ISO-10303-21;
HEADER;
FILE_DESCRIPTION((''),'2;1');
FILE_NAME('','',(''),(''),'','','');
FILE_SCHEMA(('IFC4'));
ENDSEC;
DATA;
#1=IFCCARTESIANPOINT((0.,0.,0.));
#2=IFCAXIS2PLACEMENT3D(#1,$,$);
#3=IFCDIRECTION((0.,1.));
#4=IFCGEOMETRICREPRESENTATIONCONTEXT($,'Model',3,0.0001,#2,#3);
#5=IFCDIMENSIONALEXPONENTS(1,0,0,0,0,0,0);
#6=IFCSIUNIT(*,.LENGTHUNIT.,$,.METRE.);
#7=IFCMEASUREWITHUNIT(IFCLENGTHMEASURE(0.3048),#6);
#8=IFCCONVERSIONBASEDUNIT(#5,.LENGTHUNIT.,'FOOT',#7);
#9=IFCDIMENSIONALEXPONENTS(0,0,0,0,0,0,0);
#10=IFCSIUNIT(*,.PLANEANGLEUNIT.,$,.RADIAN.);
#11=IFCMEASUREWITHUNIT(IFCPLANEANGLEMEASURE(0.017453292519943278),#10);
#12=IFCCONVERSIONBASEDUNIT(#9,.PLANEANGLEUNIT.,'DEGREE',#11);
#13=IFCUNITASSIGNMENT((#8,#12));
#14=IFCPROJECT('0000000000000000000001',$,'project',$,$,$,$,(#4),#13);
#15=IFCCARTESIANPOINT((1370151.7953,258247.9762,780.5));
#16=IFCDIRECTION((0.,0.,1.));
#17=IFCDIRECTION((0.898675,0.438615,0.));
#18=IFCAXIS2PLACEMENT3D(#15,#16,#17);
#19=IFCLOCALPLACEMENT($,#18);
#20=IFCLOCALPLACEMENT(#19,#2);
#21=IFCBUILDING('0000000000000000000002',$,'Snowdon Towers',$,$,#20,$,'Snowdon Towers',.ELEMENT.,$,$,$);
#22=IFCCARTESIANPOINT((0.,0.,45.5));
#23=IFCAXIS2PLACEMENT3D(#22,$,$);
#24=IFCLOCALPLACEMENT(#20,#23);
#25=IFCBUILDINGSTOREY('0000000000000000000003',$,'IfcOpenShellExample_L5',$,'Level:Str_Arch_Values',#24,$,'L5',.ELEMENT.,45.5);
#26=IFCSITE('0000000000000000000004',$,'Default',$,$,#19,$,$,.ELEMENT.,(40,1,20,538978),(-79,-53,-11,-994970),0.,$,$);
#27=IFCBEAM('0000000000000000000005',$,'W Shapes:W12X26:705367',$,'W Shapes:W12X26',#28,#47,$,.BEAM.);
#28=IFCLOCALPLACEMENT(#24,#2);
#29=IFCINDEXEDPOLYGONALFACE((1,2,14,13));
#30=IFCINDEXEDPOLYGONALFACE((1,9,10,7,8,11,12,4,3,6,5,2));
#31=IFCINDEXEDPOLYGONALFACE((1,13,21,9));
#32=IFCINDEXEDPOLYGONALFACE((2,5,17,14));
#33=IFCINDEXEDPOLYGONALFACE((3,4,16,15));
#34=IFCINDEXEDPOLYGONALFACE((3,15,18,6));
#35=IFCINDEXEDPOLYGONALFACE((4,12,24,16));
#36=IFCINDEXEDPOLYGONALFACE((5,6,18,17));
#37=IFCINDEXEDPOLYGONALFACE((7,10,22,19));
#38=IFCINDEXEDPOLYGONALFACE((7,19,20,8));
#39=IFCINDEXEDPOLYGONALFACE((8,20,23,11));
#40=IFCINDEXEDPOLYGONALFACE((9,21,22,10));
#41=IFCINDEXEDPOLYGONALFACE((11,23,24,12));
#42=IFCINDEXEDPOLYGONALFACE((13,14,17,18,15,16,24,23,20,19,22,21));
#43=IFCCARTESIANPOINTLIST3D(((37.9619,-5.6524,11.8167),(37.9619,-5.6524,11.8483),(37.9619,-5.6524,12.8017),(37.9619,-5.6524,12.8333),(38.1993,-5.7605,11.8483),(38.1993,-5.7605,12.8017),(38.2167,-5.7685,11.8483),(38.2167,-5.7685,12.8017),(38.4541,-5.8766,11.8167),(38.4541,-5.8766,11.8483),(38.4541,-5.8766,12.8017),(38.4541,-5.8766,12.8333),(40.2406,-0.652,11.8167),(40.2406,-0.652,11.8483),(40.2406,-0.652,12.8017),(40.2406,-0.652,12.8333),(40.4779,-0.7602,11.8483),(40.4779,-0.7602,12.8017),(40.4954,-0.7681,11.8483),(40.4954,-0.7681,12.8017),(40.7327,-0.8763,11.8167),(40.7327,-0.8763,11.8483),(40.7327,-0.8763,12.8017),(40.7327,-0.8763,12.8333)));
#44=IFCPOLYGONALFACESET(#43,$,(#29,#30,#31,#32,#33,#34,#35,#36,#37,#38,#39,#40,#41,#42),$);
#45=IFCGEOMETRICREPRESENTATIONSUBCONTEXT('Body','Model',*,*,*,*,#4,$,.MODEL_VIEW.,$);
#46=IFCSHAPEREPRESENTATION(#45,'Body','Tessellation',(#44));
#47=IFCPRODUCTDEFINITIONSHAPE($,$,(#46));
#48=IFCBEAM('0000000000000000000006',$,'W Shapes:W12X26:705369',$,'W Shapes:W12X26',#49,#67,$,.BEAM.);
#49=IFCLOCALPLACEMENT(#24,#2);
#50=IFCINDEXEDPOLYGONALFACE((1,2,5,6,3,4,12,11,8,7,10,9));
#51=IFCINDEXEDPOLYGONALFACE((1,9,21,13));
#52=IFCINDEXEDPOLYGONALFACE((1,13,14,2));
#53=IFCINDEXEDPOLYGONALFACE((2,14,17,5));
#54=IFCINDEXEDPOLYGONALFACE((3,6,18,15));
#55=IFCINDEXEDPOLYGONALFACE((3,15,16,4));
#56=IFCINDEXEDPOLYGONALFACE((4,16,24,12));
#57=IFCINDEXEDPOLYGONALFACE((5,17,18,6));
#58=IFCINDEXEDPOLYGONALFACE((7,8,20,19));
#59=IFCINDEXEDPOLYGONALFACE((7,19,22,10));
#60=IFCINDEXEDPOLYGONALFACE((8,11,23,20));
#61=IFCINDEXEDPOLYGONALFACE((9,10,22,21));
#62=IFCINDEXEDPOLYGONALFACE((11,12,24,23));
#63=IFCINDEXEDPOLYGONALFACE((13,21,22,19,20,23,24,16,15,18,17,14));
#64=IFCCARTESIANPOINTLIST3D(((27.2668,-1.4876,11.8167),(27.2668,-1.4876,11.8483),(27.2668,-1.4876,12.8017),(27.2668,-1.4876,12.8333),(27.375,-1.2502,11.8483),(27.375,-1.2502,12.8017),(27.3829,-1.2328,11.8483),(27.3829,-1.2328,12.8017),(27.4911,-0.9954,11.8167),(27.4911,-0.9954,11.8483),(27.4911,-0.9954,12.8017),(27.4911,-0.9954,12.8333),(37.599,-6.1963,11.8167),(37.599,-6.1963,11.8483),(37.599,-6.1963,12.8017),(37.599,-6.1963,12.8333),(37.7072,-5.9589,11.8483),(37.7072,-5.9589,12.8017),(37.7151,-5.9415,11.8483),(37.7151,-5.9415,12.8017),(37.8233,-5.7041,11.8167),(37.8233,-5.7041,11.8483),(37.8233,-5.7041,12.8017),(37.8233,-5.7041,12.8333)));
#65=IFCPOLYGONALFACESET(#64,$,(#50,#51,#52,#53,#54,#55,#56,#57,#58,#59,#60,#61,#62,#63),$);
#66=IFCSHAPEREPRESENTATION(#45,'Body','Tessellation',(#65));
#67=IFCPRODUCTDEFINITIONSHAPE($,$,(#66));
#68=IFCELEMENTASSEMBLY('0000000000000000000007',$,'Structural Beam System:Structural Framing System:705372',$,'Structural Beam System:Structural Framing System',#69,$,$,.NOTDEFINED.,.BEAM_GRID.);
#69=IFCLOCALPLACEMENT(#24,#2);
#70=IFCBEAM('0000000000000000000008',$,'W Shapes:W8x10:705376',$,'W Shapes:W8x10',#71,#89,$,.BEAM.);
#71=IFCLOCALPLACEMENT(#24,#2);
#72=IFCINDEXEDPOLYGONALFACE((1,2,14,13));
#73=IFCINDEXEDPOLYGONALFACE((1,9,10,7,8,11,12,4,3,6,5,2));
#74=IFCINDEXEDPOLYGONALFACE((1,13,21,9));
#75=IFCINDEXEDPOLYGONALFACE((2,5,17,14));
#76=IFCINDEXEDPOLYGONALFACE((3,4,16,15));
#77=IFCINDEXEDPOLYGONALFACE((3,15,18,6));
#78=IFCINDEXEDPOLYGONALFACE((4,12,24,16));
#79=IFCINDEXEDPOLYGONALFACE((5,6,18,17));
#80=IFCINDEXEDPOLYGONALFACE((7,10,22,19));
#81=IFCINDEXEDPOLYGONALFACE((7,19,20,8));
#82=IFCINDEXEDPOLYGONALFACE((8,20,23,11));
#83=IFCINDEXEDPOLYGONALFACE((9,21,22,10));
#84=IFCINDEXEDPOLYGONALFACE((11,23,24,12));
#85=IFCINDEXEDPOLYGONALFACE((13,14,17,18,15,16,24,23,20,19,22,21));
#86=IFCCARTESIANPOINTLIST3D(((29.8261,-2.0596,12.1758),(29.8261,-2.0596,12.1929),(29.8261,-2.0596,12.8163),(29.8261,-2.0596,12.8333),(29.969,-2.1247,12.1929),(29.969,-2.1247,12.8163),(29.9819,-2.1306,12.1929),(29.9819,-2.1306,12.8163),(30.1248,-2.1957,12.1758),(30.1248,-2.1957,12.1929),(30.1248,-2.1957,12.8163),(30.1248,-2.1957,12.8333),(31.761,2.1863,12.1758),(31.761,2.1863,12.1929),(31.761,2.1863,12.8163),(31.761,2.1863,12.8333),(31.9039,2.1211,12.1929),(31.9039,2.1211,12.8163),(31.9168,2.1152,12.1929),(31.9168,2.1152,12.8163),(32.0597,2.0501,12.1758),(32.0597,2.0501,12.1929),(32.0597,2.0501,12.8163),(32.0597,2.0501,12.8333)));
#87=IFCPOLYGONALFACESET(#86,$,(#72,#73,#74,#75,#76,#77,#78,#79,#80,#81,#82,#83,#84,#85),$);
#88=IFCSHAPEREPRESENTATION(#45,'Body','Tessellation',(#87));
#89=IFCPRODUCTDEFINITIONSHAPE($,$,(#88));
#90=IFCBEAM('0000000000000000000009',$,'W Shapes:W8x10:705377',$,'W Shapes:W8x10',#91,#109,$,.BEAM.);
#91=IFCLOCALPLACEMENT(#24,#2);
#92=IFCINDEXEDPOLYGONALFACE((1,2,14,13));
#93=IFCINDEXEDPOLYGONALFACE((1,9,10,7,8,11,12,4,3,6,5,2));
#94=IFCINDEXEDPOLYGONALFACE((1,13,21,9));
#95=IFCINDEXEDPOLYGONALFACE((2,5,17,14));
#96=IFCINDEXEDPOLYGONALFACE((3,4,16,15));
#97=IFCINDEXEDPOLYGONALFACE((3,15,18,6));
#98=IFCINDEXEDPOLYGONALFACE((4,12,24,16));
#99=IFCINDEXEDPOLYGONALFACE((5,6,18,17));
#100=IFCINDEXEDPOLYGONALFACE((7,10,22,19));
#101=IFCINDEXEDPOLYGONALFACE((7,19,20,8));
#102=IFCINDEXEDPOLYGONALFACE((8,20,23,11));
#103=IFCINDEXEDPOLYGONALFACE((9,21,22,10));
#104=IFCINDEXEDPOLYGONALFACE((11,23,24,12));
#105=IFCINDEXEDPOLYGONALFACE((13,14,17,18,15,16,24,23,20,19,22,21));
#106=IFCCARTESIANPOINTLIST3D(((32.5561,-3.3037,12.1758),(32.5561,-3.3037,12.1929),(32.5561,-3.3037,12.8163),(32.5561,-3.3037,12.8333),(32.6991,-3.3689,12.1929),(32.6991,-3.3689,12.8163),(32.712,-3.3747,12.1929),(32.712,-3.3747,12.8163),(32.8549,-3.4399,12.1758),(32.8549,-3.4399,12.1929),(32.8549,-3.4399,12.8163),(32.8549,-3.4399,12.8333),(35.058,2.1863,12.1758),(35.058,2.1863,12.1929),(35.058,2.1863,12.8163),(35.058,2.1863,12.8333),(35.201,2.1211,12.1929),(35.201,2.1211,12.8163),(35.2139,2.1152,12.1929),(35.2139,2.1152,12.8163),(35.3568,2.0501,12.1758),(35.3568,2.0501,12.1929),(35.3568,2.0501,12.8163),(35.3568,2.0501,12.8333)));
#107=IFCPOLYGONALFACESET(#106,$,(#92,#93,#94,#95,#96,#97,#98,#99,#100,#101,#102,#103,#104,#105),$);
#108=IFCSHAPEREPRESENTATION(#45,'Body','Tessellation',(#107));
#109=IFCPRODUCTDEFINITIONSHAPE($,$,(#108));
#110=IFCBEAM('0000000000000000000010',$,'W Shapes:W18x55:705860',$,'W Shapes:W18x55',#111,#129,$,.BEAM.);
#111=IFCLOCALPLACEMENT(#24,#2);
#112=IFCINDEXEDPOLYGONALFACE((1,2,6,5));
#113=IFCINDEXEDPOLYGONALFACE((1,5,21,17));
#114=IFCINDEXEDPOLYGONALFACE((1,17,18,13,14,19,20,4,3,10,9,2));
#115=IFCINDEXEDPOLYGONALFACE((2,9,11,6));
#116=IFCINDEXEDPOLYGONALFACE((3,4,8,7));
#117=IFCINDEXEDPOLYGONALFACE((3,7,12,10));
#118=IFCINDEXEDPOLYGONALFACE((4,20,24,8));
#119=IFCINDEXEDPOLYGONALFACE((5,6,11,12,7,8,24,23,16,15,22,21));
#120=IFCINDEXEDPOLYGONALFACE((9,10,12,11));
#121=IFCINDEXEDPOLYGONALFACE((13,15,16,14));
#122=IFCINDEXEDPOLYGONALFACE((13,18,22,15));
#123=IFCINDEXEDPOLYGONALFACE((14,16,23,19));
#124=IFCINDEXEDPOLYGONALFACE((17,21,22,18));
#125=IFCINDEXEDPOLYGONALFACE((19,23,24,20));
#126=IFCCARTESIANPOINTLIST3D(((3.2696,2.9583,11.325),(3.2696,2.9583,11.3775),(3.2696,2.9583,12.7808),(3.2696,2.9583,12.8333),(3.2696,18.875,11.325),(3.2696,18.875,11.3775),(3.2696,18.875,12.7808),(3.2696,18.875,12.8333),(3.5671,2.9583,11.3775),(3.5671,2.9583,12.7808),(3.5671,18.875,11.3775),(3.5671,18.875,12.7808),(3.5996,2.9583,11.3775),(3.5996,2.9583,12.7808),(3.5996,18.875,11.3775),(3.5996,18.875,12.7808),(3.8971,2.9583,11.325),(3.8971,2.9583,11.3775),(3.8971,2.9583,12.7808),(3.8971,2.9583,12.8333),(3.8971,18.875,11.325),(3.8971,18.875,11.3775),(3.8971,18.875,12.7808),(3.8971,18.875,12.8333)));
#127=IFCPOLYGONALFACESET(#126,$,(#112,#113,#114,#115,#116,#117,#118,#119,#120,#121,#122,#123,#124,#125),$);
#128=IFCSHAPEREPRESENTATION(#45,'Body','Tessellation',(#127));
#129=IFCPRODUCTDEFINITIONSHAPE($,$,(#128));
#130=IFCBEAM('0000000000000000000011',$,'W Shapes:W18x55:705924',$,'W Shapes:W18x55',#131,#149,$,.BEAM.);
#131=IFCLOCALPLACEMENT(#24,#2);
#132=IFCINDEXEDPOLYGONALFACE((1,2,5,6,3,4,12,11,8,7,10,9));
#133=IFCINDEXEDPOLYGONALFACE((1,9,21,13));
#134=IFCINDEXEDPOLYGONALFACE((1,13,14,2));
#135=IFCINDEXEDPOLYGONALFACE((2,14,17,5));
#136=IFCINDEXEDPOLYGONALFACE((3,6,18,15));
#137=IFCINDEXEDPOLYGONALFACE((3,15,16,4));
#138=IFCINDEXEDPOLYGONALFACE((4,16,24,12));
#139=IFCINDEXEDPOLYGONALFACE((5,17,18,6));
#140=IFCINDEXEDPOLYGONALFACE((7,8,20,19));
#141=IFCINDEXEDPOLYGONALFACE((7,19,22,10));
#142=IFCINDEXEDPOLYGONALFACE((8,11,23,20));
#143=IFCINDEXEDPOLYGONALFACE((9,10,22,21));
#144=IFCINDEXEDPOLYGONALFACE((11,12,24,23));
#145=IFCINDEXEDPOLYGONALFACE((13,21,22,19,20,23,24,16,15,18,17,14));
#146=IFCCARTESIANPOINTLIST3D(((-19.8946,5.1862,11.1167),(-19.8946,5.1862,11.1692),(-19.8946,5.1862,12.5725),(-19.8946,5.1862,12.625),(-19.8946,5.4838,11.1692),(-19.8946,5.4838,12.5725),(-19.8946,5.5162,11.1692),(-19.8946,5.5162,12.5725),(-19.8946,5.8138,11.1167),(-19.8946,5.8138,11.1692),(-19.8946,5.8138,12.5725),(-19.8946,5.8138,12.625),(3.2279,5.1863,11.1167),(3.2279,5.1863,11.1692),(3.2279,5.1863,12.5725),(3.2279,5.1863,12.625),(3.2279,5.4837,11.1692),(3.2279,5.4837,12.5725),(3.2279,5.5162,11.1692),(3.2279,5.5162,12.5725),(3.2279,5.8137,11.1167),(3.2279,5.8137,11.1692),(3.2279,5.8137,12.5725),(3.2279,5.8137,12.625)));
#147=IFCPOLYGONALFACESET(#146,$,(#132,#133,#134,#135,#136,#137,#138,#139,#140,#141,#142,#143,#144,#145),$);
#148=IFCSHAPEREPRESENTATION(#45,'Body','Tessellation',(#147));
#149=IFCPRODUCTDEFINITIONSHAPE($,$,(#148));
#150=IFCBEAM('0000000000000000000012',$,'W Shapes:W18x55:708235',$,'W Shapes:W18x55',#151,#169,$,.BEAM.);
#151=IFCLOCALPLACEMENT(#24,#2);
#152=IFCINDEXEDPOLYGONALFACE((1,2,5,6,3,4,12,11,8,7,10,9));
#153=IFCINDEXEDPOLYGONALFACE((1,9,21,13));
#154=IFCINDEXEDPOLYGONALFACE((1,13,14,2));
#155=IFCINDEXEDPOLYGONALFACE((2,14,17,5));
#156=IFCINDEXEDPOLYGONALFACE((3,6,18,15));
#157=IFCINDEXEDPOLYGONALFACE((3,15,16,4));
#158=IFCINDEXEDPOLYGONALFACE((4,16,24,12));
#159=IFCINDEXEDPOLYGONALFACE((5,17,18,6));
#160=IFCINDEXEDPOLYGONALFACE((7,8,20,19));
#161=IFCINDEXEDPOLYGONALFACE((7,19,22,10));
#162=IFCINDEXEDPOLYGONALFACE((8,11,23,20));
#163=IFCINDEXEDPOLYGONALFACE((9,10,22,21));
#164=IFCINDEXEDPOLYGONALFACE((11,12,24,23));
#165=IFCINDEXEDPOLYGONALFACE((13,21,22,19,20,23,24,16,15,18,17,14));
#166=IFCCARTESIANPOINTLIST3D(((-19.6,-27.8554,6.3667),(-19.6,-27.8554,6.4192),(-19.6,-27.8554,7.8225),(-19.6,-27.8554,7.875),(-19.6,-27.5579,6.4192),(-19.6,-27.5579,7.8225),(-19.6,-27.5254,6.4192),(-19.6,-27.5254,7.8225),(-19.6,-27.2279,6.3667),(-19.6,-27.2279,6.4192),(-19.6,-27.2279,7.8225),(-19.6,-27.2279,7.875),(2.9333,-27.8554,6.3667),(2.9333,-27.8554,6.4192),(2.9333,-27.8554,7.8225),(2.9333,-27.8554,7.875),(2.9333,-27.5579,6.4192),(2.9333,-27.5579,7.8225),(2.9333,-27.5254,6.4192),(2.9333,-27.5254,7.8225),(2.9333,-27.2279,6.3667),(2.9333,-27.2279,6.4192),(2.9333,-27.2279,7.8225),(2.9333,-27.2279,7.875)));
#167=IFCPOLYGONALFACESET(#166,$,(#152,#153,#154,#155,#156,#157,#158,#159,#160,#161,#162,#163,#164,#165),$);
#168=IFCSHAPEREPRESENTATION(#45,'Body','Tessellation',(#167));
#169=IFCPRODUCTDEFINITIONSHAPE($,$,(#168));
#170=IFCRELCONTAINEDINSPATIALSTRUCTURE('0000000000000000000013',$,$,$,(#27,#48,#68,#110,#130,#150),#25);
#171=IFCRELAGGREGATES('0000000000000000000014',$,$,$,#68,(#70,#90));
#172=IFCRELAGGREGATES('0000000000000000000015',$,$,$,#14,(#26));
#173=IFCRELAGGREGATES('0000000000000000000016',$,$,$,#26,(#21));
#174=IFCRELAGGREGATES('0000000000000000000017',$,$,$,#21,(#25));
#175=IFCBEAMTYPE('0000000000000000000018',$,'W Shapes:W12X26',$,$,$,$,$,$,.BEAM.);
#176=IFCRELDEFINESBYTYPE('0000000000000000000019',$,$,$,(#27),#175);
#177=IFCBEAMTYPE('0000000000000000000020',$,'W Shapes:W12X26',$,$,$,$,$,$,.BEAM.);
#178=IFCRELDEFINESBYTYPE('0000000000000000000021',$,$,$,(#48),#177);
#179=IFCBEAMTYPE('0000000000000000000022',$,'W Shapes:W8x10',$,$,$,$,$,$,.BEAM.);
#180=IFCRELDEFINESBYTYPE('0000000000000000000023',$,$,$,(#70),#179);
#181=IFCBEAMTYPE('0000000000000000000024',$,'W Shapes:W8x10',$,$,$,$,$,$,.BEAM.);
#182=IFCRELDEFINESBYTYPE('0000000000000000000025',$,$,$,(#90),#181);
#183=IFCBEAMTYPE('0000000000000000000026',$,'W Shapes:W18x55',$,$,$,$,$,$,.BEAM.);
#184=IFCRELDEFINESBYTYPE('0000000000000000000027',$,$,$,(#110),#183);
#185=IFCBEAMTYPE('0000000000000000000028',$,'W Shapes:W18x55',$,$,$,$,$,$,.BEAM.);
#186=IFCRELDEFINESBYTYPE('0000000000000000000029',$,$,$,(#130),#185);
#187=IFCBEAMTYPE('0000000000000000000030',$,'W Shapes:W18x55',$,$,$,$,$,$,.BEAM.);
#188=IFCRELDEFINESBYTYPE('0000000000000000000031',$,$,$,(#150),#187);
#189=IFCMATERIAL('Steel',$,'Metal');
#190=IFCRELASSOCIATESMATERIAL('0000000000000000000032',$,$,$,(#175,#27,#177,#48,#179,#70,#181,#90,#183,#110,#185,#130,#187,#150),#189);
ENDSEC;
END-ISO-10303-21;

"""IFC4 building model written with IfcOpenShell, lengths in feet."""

from ifc_helpers import new_model, entity, si_unit, converted_unit, direction, frame, origin, place, context, subcontext, project, spatial, indexed_curve, outline, extrude, source, transform, mapped, material, type_object, type_shapes, element, aggregate, save


model = new_model("IFC4")

# Units and contexts
model_context = context("Model", 3, precision=0.0001, world=origin(), true_north=direction((0.0, 1.0)))
body_context = subcontext(model_context, "Body", "Model", "MODEL_VIEW")
ifc_project = project(units=[converted_unit("LENGTHUNIT", "FOOT", entity("IfcLengthMeasure", 0.3048), si_unit("LENGTHUNIT", "METRE"), dimensions=[1, 0, 0, 0, 0, 0, 0]), converted_unit("PLANEANGLEUNIT", "DEGREE", entity("IfcPlaneAngleMeasure", 0.017453292519943278), si_unit("PLANEANGLEUNIT", "RADIAN"), dimensions=[0, 0, 0, 0, 0, 0, 0])], contexts=[model_context])

# Site, building, storey
site_placement = place(None, frame((1370151.7953, 258247.9762, 780.5), z_axis=(0.0, 0.0, 1.0), x_axis=(0.898675, 0.438615, 0.0)))
site = spatial("IfcSite", under=ifc_project, at=site_placement, Name="Default", CompositionType="ELEMENT", RefLatitude=(40, 1, 20, 538978), RefLongitude=(-79, -53, -11, -994970), RefElevation=0.0)
building_placement = place(site_placement, origin())
building = spatial("IfcBuilding", under=site, at=building_placement, Name="Snowdon Towers", LongName="Snowdon Towers", CompositionType="ELEMENT")
storey_placement = place(building_placement, frame((0.0, 0.0, 45.5)))
storey = spatial("IfcBuildingStorey", under=building, at=storey_placement, Name="IfcOpenShellExample_L5", ObjectType="Level:Str_Arch_Values", LongName="L5", CompositionType="ELEMENT", Elevation=45.5)

# Shared definitions
ifc_material = material(Name="Steel", Category="Metal")

# Beams
beam_type_1 = type_object("IfcBeamType", Name="W Shapes:W12X26", PredefinedType="BEAM", material=ifc_material)
shared_shape_1 = source(origin(), body_context, "Body", "SweptSolid", [
    extrude(outline(indexed_curve([(-0.2704, -0.4767), (-0.2704, -0.5083), (0.2704, -0.5083), (0.2704, -0.4767), (0.0096, -0.4767), (0.0096, 0.4767), (0.2704, 0.4767), (0.2704, 0.5083), (-0.2704, 0.5083), (-0.2704, 0.4767), (-0.0096, 0.4767), (-0.0096, -0.4767), (-0.2704, -0.4767)], self_intersect=False)), frame((-3.4805, 0.0, 0.0), z_axis=(-1.0, 0.0, 0.0), x_axis=(0.0, -1.0, 0.0)), (0.0, 0.0, -1.0), 5.4951),
])
type_shapes(beam_type_1, [shared_shape_1])
beam_1_placement = place(storey_placement, frame((39.6512, -2.5974, 12.325), z_axis=(0.0, 0.0, 1.0), x_axis=(0.414671, 0.909972, 0.0)))
element("IfcBeam", 1, at=beam_1_placement, inside=storey, type_object=beam_type_1, material=ifc_material, Name="W Shapes:W12X26:705367", ObjectType="W Shapes:W12X26", PredefinedType="BEAM", context=body_context, shape_type="MappedRepresentation", body=[
    mapped(shared_shape_1, transform((0.0, 0.0, 0.0), scale=1.0)),
])
beam_type_2 = type_object("IfcBeamType", Name="W Shapes:W12X26", PredefinedType="BEAM", material=ifc_material)
shared_shape_2 = source(origin(), body_context, "Body", "SweptSolid", [
    extrude(outline(indexed_curve([(-0.2704, -0.4767), (-0.2704, -0.5083), (0.2704, -0.5083), (0.2704, -0.4767), (0.0096, -0.4767), (0.0096, 0.4767), (0.2704, 0.4767), (0.2704, 0.5083), (-0.2704, 0.5083), (-0.2704, 0.4767), (-0.0096, 0.4767), (-0.0096, -0.4767), (-0.2704, -0.4767)], self_intersect=False)), frame((-5.7296, 0.0, 0.0), z_axis=(-1.0, 0.0, 0.0), x_axis=(0.0, -1.0, 0.0)), (0.0, 0.0, -1.0), 11.3546),
])
type_shapes(beam_type_2, [shared_shape_2])
beam_2_placement = place(storey_placement, frame((32.5926, -3.6175, 12.325), z_axis=(0.0, 0.0, 1.0), x_axis=(0.909961, -0.414693, 0.0)))
element("IfcBeam", 2, at=beam_2_placement, inside=storey, type_object=beam_type_2, material=ifc_material, Name="W Shapes:W12X26:705369", ObjectType="W Shapes:W12X26", PredefinedType="BEAM", context=body_context, shape_type="MappedRepresentation", body=[
    mapped(shared_shape_2, transform((0.0, 0.0, 0.0), scale=1.0)),
])

# Element assembly, beams
assembly_1_placement = place(storey_placement, origin())
assembly_1 = element("IfcElementAssembly", 3, at=assembly_1_placement, inside=storey, Name="Structural Beam System:Structural Framing System:705372", ObjectType="Structural Beam System:Structural Framing System", AssemblyPlace="NOTDEFINED", PredefinedType="BEAM_GRID")
beam_type_3 = type_object("IfcBeamType", Name="W Shapes:W8x10", PredefinedType="BEAM", material=ifc_material)
shared_shape_3 = source(origin(), body_context, "Body", "SweptSolid", [
    extrude(outline(indexed_curve([(-0.1642, -0.3117), (-0.1642, -0.3288), (0.1642, -0.3288), (0.1642, -0.3117), (0.0071, -0.3117), (0.0071, 0.3117), (0.1642, 0.3117), (0.1642, 0.3287), (-0.1642, 0.3287), (-0.1642, 0.3117), (-0.0071, 0.3117), (-0.0071, -0.3117), (-0.1642, -0.3117)], self_intersect=False)), frame((-2.4076, 0.0, 0.0), z_axis=(-1.0, 0.0, 0.0), x_axis=(0.0, -1.0, 0.0)), (0.0, 0.0, -1.0), 4.6659),
])
type_shapes(beam_type_3, [shared_shape_3])
beam_3_placement = place(assembly_1_placement, frame((30.9738, 0.0631, 12.5046), z_axis=(0.0, 0.0, 1.0), x_axis=(0.414693, 0.909961, 0.0)))
beam_3 = element("IfcBeam", 4, at=beam_3_placement, type_object=beam_type_3, material=ifc_material, Name="W Shapes:W8x10:705376", ObjectType="W Shapes:W8x10", PredefinedType="BEAM", context=body_context, shape_type="MappedRepresentation", body=[
    mapped(shared_shape_3, transform((0.0, 0.0, 0.0), scale=1.0)),
])
beam_type_4 = type_object("IfcBeamType", Name="W Shapes:W8x10", PredefinedType="BEAM", material=ifc_material)
shared_shape_4 = source(origin(), body_context, "Body", "SweptSolid", [
    extrude(outline(indexed_curve([(-0.1642, -0.3117), (-0.1642, -0.3288), (0.1642, -0.3288), (0.1642, -0.3117), (0.0071, -0.3117), (0.0071, 0.3117), (0.1642, 0.3117), (0.1642, 0.3287), (-0.1642, 0.3287), (-0.1642, 0.3117), (-0.0071, 0.3117), (-0.0071, -0.3117), (-0.1642, -0.3117)], self_intersect=False)), frame((-3.0912, 0.0, 0.0), z_axis=(-1.0, 0.0, 0.0), x_axis=(0.0, -1.0, 0.0)), (0.0, 0.0, -1.0), 6.0332),
])
type_shapes(beam_type_4, [shared_shape_4])
beam_4_placement = place(assembly_1_placement, frame((33.9874, -0.5589, 12.5046), z_axis=(0.0, 0.0, 1.0), x_axis=(0.414693, 0.909961, 0.0)))
beam_4 = element("IfcBeam", 5, at=beam_4_placement, type_object=beam_type_4, material=ifc_material, Name="W Shapes:W8x10:705377", ObjectType="W Shapes:W8x10", PredefinedType="BEAM", context=body_context, shape_type="MappedRepresentation", body=[
    mapped(shared_shape_4, transform((0.0, 0.0, 0.0), scale=1.0)),
])

# Beams
beam_type_5 = type_object("IfcBeamType", Name="W Shapes:W18x55", PredefinedType="BEAM", material=ifc_material)
shared_shape_5 = source(origin(), body_context, "Body", "SweptSolid", [
    extrude(outline(indexed_curve([(-0.3138, -0.7017), (-0.3138, -0.7542), (0.3138, -0.7542), (0.3138, -0.7017), (0.0162, -0.7017), (0.0162, 0.7017), (0.3138, 0.7017), (0.3138, 0.7542), (-0.3137, 0.7542), (-0.3137, 0.7017), (-0.0163, 0.7017), (-0.0163, -0.7017), (-0.3138, -0.7017)], self_intersect=False)), frame((-7.7292, 0.0, 0.0), z_axis=(-1.0, 0.0, 0.0), x_axis=(0.0, -1.0, 0.0)), (0.0, 0.0, -1.0), 15.9167),
])
type_shapes(beam_type_5, [shared_shape_5])
beam_5_placement = place(storey_placement, frame((3.5833, 10.6875, 12.0792), z_axis=(0.0, 0.0, 1.0), x_axis=(0.0, 1.0, 0.0)))
element("IfcBeam", 6, at=beam_5_placement, inside=storey, type_object=beam_type_5, material=ifc_material, Name="W Shapes:W18x55:705860", ObjectType="W Shapes:W18x55", PredefinedType="BEAM", context=body_context, shape_type="MappedRepresentation", body=[
    mapped(shared_shape_5, transform((0.0, 0.0, 0.0), scale=1.0)),
])
beam_type_6 = type_object("IfcBeamType", Name="W Shapes:W18x55", PredefinedType="BEAM", material=ifc_material)
shared_shape_6 = source(origin(), body_context, "Body", "SweptSolid", [
    extrude(outline(indexed_curve([(-0.3138, -0.7017), (-0.3138, -0.7542), (0.3138, -0.7542), (0.3138, -0.7017), (0.0162, -0.7017), (0.0162, 0.7017), (0.3138, 0.7017), (0.3138, 0.7542), (-0.3137, 0.7542), (-0.3137, 0.7017), (-0.0163, 0.7017), (-0.0163, -0.7017), (-0.3138, -0.7017)], self_intersect=False)), frame((-11.5612, 0.0, 0.0), z_axis=(-1.0, 0.0, 0.0), x_axis=(0.0, -1.0, 0.0)), (0.0, 0.0, -1.0), 23.1225),
])
type_shapes(beam_type_6, [shared_shape_6])
beam_6_placement = place(storey_placement, frame((-8.3333, 5.5, 11.8708)))
element("IfcBeam", 7, at=beam_6_placement, inside=storey, type_object=beam_type_6, material=ifc_material, Name="W Shapes:W18x55:705924", ObjectType="W Shapes:W18x55", PredefinedType="BEAM", context=body_context, shape_type="MappedRepresentation", body=[
    mapped(shared_shape_6, transform((0.0, 0.0, 0.0), scale=1.0)),
])
beam_type_7 = type_object("IfcBeamType", Name="W Shapes:W18x55", PredefinedType="BEAM", material=ifc_material)
shared_shape_7 = source(origin(), body_context, "Body", "SweptSolid", [
    extrude(outline(indexed_curve([(-0.3138, -0.7017), (-0.3138, -0.7542), (0.3138, -0.7542), (0.3138, -0.7017), (0.0162, -0.7017), (0.0162, 0.7017), (0.3138, 0.7017), (0.3138, 0.7542), (-0.3137, 0.7542), (-0.3137, 0.7017), (-0.0163, 0.7017), (-0.0163, -0.7017), (-0.3138, -0.7017)], self_intersect=False)), frame((-11.2667, 0.0, 0.0), z_axis=(-1.0, 0.0, 0.0), x_axis=(0.0, -1.0, 0.0)), (0.0, 0.0, -1.0), 22.5333),
])
type_shapes(beam_type_7, [shared_shape_7])
beam_7_placement = place(storey_placement, frame((-8.3333, -27.5417, 7.1208)))
element("IfcBeam", 8, at=beam_7_placement, inside=storey, type_object=beam_type_7, material=ifc_material, Name="W Shapes:W18x55:708235", ObjectType="W Shapes:W18x55", PredefinedType="BEAM", context=body_context, shape_type="MappedRepresentation", body=[
    mapped(shared_shape_7, transform((0.0, 0.0, 0.0), scale=1.0)),
])

aggregate(assembly_1, [beam_3, beam_4])

save(model, "model.ifc")
